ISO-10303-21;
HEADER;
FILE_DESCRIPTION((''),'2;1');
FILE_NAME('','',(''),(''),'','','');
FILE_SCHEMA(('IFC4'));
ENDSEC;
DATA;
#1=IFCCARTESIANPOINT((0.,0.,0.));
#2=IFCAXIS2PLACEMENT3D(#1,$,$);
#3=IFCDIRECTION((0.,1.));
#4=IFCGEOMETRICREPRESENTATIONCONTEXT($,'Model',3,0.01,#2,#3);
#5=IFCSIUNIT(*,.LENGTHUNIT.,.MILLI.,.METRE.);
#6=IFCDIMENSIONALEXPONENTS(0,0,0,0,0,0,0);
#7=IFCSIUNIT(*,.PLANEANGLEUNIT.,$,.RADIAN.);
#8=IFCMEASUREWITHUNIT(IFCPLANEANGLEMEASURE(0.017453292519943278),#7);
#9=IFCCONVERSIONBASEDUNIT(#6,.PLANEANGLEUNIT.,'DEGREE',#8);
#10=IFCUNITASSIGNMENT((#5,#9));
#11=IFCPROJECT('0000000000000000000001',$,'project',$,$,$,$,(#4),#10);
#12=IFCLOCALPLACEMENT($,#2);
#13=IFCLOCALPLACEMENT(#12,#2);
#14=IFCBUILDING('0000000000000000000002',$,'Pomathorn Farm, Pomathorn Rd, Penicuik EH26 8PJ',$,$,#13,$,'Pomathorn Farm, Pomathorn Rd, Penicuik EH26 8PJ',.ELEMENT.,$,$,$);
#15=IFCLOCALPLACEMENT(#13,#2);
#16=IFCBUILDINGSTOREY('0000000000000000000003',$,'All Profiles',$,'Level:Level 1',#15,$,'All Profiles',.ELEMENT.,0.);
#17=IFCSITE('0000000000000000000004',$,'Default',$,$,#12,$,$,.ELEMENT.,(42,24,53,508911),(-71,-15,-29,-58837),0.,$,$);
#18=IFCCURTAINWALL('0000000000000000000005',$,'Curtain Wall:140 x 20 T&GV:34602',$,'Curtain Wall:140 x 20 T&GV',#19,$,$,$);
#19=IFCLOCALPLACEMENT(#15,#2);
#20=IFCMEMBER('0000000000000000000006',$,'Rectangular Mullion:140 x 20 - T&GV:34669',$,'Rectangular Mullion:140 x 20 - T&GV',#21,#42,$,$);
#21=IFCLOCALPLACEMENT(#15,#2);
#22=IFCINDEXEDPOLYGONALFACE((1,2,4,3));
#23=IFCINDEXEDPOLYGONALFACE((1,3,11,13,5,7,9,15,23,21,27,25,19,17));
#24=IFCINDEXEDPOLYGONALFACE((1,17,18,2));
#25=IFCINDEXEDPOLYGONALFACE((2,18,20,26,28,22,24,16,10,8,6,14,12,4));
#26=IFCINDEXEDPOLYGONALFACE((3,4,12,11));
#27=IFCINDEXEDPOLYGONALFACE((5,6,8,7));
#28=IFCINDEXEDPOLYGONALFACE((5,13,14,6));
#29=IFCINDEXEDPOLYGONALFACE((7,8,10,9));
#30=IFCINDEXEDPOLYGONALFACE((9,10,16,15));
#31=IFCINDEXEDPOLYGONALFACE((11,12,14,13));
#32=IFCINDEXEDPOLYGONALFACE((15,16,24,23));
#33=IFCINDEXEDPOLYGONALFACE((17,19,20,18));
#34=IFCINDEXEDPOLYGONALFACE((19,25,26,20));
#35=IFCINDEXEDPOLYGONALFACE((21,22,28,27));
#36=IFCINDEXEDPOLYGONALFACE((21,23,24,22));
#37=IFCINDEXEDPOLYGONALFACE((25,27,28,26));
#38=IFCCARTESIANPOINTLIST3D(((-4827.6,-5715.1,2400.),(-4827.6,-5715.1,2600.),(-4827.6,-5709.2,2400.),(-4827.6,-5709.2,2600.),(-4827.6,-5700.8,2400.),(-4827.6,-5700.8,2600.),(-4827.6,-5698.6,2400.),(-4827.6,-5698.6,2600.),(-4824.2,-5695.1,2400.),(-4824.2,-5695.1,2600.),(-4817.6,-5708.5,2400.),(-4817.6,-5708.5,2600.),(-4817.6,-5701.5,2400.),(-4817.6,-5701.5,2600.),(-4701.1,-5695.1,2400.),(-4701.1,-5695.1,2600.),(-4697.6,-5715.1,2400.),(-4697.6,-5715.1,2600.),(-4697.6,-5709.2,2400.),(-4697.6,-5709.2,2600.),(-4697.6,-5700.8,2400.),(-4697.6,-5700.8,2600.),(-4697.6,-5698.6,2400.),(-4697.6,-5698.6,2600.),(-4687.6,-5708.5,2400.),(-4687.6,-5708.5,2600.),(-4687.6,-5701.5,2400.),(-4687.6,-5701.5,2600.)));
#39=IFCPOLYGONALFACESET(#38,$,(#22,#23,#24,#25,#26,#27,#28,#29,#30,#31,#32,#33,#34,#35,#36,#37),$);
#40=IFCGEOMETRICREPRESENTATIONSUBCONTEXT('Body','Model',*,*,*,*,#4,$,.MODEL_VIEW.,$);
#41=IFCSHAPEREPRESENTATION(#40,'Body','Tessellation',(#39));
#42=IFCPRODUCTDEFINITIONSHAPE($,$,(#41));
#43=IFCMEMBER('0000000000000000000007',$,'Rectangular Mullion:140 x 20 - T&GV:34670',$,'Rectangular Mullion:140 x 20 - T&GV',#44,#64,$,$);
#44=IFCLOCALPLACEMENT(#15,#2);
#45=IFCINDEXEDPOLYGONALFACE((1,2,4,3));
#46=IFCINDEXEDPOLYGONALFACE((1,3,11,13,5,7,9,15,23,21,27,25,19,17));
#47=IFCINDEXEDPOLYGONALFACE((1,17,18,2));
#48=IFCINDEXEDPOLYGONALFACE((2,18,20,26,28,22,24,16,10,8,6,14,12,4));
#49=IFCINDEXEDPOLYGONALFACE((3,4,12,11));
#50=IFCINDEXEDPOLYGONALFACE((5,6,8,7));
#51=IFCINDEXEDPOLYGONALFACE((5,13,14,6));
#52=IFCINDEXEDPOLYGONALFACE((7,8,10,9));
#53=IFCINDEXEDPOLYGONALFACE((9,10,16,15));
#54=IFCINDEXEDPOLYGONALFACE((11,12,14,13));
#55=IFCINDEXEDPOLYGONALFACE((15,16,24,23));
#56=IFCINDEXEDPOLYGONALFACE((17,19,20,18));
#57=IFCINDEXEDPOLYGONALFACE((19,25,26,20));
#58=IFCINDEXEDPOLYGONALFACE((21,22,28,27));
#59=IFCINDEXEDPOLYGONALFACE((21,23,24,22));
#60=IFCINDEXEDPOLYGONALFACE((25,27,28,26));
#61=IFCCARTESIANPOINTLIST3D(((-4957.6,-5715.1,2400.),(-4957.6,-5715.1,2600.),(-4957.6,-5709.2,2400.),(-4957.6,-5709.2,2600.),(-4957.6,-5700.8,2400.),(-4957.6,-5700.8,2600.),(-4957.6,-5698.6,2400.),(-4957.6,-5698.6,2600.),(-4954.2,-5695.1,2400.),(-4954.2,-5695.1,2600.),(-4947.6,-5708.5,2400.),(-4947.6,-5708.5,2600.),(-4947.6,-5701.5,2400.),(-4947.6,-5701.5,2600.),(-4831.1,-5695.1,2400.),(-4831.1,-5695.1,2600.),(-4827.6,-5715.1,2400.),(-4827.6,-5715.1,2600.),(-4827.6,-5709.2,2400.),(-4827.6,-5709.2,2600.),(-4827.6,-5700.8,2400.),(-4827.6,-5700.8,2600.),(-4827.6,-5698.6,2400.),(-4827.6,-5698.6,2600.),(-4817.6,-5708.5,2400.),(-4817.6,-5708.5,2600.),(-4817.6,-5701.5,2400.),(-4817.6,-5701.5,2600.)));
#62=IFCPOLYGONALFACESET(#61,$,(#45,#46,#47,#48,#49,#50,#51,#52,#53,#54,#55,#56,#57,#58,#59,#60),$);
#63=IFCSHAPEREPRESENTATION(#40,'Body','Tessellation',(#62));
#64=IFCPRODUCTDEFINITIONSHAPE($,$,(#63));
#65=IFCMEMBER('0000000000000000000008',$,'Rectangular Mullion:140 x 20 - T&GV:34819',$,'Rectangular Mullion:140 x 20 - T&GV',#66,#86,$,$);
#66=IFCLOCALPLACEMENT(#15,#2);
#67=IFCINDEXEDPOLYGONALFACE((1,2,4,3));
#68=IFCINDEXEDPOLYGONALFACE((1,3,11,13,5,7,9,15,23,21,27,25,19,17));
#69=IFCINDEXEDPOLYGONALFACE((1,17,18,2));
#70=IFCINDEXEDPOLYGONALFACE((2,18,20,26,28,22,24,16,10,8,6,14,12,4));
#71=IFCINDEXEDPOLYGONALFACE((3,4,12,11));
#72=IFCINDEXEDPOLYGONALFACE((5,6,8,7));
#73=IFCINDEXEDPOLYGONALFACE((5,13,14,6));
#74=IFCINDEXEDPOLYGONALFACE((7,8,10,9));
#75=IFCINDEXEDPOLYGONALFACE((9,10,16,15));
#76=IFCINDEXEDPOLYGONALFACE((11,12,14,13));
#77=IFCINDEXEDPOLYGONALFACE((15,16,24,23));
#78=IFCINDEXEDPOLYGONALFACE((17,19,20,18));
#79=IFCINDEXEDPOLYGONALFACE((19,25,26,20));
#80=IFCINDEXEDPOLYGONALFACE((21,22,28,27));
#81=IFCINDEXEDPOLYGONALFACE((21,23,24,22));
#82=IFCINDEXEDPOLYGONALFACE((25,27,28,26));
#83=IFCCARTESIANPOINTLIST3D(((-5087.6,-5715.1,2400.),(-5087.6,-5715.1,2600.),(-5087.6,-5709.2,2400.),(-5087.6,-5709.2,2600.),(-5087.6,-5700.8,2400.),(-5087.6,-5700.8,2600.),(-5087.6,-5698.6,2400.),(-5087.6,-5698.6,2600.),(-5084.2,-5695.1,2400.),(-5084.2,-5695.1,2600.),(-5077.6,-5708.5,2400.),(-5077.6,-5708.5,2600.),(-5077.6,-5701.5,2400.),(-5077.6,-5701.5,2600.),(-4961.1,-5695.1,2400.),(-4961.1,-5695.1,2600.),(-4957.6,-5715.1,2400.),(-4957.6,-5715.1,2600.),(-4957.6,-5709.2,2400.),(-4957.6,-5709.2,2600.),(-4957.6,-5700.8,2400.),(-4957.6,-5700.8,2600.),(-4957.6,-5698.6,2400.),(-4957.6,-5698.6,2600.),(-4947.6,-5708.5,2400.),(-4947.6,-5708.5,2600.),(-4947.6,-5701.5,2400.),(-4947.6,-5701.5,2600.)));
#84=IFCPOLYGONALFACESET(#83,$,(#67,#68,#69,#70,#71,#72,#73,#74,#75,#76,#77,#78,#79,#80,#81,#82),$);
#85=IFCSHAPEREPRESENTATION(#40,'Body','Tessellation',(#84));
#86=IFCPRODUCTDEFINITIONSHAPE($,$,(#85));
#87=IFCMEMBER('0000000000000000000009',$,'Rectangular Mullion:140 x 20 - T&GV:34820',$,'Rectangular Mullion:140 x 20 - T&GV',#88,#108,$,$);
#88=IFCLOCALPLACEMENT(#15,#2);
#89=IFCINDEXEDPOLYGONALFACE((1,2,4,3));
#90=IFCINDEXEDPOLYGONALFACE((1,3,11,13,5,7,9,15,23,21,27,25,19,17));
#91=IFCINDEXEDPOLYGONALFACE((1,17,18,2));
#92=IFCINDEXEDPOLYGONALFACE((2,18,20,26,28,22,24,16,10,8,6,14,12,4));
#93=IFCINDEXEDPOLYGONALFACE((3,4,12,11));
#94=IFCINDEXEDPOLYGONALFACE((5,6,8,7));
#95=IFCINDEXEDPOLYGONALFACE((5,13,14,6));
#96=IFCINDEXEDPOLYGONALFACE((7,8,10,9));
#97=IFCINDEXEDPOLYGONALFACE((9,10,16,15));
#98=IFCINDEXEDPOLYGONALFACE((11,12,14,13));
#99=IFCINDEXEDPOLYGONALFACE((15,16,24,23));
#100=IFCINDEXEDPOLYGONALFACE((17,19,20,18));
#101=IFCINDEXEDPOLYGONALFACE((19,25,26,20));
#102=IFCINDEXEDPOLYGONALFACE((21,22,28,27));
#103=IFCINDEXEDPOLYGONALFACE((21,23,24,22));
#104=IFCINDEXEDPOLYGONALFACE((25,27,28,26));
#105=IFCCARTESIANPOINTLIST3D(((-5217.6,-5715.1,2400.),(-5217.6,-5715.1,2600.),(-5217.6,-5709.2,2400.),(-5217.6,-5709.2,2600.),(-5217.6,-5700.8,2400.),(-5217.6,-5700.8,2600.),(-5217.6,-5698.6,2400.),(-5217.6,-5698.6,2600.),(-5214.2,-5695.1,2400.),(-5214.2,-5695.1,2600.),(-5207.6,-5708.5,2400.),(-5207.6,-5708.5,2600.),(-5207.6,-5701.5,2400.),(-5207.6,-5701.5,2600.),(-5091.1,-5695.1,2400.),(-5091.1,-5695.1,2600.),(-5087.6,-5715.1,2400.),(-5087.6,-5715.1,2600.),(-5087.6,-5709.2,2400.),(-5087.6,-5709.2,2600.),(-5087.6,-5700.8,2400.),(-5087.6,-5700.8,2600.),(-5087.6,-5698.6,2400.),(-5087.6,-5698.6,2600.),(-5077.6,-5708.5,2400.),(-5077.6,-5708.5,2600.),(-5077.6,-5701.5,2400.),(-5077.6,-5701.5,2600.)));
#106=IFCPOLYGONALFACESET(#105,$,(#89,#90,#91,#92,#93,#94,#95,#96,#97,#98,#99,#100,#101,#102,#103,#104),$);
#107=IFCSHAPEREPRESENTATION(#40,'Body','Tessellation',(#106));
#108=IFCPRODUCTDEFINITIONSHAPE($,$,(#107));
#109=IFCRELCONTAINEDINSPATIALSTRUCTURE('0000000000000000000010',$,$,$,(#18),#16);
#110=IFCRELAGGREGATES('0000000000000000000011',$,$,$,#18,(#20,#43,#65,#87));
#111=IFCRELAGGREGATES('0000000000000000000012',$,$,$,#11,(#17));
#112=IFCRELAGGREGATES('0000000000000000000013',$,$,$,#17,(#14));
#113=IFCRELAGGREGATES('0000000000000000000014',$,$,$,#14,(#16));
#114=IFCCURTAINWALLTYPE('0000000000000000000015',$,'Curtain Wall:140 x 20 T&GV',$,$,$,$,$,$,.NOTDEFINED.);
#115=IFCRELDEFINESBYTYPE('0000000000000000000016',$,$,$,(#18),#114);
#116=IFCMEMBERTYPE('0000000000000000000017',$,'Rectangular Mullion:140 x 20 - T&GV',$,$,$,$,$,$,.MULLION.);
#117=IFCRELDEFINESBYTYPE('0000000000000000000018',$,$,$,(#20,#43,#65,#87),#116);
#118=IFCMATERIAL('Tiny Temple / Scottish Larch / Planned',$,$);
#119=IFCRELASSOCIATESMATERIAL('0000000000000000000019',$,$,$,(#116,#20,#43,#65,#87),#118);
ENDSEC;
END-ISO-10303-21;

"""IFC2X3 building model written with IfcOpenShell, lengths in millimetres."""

from ifc_helpers import new_model, entity, si_unit, converted_unit, direction, frame, origin, place, context, subcontext, project, spatial, polyline, outline, extrude, source, transform, mapped, material, type_object, type_shapes, element, aggregate, save


model = new_model("IFC2X3")

# Units and contexts
model_context = context("Model", 3, precision=0.01, world=origin(), true_north=direction((0.0, 1.0)))
body_context = subcontext(model_context, "Body", "Model", "MODEL_VIEW")
ifc_project = project(units=[si_unit("LENGTHUNIT", "METRE", prefix="MILLI"), converted_unit("PLANEANGLEUNIT", "DEGREE", entity("IfcPlaneAngleMeasure", 0.017453292519943278), si_unit("PLANEANGLEUNIT", "RADIAN"), dimensions=[0, 0, 0, 0, 0, 0, 0])], contexts=[model_context])

# Site, building, storey
site_placement = place(None, origin())
site = spatial("IfcSite", under=ifc_project, at=site_placement, Name="Default", CompositionType="ELEMENT", RefLatitude=(42, 24, 53, 508911), RefLongitude=(-71, -15, -29, -58837), RefElevation=0.0)
building_placement = place(site_placement, origin())
building = spatial("IfcBuilding", under=site, at=building_placement, Name="Pomathorn Farm, Pomathorn Rd, Penicuik EH26 8PJ", LongName="Pomathorn Farm, Pomathorn Rd, Penicuik EH26 8PJ", CompositionType="ELEMENT")
storey_placement = place(building_placement, origin())
storey = spatial("IfcBuildingStorey", under=building, at=storey_placement, Name="All Profiles", ObjectType="Level:Level 1", LongName="All Profiles", CompositionType="ELEMENT", Elevation=0.0)

# Curtain wall, members
ifc_material = material(Name="Tiny Temple / Scottish Larch / Planned")
curtain_wall_type_1 = type_object("IfcCurtainWallType", Name="Curtain Wall:140 x 20 T&GV", PredefinedType="NOTDEFINED")
curtain_wall_1_placement = place(storey_placement, origin())
curtain_wall_1 = element("IfcCurtainWall", 1, at=curtain_wall_1_placement, inside=storey, type_object=curtain_wall_type_1, Name="Curtain Wall:140 x 20 T&GV:34602", ObjectType="Curtain Wall:140 x 20 T&GV")
member_type_1 = type_object("IfcMemberType", Name="Rectangular Mullion:140 x 20 - T&GV", PredefinedType="MULLION", material=ifc_material)
shared_shape_1 = source(origin(), body_context, "Body", "SweptSolid", [
    extrude(outline(polyline([(-62.1, -11.0), (67.9, -11.0), (67.9, -5.1), (57.9, -4.4), (57.9, 2.6), (67.9, 3.3), (67.9, 5.5), (64.4, 9.0), (-58.7, 9.0), (-62.1, 5.5), (-62.1, 3.3), (-72.1, 2.6), (-72.1, -4.4), (-62.1, -5.1), (-62.1, -11.0)])), frame((-72.1, -11.0, -200.0), z_axis=(0.0, 0.0, 1.0), x_axis=(-1.0, 0.0, 0.0)), (0.0, 0.0, 1.0), 200.0),
])
type_shapes(member_type_1, [shared_shape_1])
member_1_placement = place(curtain_wall_1_placement, frame((-4687.6, -5715.1, 2400.0), z_axis=(0.0, 0.0, -1.0), x_axis=(1.0, 0.0, 0.0)))
member_1 = element("IfcMember", 2, at=member_1_placement, type_object=member_type_1, material=ifc_material, Name="Rectangular Mullion:140 x 20 - T&GV:34669", ObjectType="Rectangular Mullion:140 x 20 - T&GV", context=body_context, shape_type="MappedRepresentation", body=[
    mapped(shared_shape_1, transform((0.0, 0.0, 0.0), scale=1.0)),
])
member_2_placement = place(curtain_wall_1_placement, frame((-4817.6, -5715.1, 2400.0), z_axis=(0.0, 0.0, -1.0), x_axis=(1.0, 0.0, 0.0)))
member_2 = element("IfcMember", 3, at=member_2_placement, type_object=member_type_1, material=ifc_material, Name="Rectangular Mullion:140 x 20 - T&GV:34670", ObjectType="Rectangular Mullion:140 x 20 - T&GV", context=body_context, shape_type="MappedRepresentation", body=[
    mapped(shared_shape_1, transform((0.0, 0.0, 0.0), scale=1.0)),
])
member_3_placement = place(curtain_wall_1_placement, frame((-4947.6, -5715.1, 2400.0), z_axis=(0.0, 0.0, -1.0), x_axis=(1.0, 0.0, 0.0)))
member_3 = element("IfcMember", 4, at=member_3_placement, type_object=member_type_1, material=ifc_material, Name="Rectangular Mullion:140 x 20 - T&GV:34819", ObjectType="Rectangular Mullion:140 x 20 - T&GV", context=body_context, shape_type="MappedRepresentation", body=[
    mapped(shared_shape_1, transform((0.0, 0.0, 0.0), scale=1.0)),
])
member_4_placement = place(curtain_wall_1_placement, frame((-5077.6, -5715.1, 2400.0), z_axis=(0.0, 0.0, -1.0), x_axis=(1.0, 0.0, 0.0)))
member_4 = element("IfcMember", 5, at=member_4_placement, type_object=member_type_1, material=ifc_material, Name="Rectangular Mullion:140 x 20 - T&GV:34820", ObjectType="Rectangular Mullion:140 x 20 - T&GV", context=body_context, shape_type="MappedRepresentation", body=[
    mapped(shared_shape_1, transform((0.0, 0.0, 0.0), scale=1.0)),
])
aggregate(curtain_wall_1, [member_1, member_2, member_3, member_4])

save(model, "model.ifc")
